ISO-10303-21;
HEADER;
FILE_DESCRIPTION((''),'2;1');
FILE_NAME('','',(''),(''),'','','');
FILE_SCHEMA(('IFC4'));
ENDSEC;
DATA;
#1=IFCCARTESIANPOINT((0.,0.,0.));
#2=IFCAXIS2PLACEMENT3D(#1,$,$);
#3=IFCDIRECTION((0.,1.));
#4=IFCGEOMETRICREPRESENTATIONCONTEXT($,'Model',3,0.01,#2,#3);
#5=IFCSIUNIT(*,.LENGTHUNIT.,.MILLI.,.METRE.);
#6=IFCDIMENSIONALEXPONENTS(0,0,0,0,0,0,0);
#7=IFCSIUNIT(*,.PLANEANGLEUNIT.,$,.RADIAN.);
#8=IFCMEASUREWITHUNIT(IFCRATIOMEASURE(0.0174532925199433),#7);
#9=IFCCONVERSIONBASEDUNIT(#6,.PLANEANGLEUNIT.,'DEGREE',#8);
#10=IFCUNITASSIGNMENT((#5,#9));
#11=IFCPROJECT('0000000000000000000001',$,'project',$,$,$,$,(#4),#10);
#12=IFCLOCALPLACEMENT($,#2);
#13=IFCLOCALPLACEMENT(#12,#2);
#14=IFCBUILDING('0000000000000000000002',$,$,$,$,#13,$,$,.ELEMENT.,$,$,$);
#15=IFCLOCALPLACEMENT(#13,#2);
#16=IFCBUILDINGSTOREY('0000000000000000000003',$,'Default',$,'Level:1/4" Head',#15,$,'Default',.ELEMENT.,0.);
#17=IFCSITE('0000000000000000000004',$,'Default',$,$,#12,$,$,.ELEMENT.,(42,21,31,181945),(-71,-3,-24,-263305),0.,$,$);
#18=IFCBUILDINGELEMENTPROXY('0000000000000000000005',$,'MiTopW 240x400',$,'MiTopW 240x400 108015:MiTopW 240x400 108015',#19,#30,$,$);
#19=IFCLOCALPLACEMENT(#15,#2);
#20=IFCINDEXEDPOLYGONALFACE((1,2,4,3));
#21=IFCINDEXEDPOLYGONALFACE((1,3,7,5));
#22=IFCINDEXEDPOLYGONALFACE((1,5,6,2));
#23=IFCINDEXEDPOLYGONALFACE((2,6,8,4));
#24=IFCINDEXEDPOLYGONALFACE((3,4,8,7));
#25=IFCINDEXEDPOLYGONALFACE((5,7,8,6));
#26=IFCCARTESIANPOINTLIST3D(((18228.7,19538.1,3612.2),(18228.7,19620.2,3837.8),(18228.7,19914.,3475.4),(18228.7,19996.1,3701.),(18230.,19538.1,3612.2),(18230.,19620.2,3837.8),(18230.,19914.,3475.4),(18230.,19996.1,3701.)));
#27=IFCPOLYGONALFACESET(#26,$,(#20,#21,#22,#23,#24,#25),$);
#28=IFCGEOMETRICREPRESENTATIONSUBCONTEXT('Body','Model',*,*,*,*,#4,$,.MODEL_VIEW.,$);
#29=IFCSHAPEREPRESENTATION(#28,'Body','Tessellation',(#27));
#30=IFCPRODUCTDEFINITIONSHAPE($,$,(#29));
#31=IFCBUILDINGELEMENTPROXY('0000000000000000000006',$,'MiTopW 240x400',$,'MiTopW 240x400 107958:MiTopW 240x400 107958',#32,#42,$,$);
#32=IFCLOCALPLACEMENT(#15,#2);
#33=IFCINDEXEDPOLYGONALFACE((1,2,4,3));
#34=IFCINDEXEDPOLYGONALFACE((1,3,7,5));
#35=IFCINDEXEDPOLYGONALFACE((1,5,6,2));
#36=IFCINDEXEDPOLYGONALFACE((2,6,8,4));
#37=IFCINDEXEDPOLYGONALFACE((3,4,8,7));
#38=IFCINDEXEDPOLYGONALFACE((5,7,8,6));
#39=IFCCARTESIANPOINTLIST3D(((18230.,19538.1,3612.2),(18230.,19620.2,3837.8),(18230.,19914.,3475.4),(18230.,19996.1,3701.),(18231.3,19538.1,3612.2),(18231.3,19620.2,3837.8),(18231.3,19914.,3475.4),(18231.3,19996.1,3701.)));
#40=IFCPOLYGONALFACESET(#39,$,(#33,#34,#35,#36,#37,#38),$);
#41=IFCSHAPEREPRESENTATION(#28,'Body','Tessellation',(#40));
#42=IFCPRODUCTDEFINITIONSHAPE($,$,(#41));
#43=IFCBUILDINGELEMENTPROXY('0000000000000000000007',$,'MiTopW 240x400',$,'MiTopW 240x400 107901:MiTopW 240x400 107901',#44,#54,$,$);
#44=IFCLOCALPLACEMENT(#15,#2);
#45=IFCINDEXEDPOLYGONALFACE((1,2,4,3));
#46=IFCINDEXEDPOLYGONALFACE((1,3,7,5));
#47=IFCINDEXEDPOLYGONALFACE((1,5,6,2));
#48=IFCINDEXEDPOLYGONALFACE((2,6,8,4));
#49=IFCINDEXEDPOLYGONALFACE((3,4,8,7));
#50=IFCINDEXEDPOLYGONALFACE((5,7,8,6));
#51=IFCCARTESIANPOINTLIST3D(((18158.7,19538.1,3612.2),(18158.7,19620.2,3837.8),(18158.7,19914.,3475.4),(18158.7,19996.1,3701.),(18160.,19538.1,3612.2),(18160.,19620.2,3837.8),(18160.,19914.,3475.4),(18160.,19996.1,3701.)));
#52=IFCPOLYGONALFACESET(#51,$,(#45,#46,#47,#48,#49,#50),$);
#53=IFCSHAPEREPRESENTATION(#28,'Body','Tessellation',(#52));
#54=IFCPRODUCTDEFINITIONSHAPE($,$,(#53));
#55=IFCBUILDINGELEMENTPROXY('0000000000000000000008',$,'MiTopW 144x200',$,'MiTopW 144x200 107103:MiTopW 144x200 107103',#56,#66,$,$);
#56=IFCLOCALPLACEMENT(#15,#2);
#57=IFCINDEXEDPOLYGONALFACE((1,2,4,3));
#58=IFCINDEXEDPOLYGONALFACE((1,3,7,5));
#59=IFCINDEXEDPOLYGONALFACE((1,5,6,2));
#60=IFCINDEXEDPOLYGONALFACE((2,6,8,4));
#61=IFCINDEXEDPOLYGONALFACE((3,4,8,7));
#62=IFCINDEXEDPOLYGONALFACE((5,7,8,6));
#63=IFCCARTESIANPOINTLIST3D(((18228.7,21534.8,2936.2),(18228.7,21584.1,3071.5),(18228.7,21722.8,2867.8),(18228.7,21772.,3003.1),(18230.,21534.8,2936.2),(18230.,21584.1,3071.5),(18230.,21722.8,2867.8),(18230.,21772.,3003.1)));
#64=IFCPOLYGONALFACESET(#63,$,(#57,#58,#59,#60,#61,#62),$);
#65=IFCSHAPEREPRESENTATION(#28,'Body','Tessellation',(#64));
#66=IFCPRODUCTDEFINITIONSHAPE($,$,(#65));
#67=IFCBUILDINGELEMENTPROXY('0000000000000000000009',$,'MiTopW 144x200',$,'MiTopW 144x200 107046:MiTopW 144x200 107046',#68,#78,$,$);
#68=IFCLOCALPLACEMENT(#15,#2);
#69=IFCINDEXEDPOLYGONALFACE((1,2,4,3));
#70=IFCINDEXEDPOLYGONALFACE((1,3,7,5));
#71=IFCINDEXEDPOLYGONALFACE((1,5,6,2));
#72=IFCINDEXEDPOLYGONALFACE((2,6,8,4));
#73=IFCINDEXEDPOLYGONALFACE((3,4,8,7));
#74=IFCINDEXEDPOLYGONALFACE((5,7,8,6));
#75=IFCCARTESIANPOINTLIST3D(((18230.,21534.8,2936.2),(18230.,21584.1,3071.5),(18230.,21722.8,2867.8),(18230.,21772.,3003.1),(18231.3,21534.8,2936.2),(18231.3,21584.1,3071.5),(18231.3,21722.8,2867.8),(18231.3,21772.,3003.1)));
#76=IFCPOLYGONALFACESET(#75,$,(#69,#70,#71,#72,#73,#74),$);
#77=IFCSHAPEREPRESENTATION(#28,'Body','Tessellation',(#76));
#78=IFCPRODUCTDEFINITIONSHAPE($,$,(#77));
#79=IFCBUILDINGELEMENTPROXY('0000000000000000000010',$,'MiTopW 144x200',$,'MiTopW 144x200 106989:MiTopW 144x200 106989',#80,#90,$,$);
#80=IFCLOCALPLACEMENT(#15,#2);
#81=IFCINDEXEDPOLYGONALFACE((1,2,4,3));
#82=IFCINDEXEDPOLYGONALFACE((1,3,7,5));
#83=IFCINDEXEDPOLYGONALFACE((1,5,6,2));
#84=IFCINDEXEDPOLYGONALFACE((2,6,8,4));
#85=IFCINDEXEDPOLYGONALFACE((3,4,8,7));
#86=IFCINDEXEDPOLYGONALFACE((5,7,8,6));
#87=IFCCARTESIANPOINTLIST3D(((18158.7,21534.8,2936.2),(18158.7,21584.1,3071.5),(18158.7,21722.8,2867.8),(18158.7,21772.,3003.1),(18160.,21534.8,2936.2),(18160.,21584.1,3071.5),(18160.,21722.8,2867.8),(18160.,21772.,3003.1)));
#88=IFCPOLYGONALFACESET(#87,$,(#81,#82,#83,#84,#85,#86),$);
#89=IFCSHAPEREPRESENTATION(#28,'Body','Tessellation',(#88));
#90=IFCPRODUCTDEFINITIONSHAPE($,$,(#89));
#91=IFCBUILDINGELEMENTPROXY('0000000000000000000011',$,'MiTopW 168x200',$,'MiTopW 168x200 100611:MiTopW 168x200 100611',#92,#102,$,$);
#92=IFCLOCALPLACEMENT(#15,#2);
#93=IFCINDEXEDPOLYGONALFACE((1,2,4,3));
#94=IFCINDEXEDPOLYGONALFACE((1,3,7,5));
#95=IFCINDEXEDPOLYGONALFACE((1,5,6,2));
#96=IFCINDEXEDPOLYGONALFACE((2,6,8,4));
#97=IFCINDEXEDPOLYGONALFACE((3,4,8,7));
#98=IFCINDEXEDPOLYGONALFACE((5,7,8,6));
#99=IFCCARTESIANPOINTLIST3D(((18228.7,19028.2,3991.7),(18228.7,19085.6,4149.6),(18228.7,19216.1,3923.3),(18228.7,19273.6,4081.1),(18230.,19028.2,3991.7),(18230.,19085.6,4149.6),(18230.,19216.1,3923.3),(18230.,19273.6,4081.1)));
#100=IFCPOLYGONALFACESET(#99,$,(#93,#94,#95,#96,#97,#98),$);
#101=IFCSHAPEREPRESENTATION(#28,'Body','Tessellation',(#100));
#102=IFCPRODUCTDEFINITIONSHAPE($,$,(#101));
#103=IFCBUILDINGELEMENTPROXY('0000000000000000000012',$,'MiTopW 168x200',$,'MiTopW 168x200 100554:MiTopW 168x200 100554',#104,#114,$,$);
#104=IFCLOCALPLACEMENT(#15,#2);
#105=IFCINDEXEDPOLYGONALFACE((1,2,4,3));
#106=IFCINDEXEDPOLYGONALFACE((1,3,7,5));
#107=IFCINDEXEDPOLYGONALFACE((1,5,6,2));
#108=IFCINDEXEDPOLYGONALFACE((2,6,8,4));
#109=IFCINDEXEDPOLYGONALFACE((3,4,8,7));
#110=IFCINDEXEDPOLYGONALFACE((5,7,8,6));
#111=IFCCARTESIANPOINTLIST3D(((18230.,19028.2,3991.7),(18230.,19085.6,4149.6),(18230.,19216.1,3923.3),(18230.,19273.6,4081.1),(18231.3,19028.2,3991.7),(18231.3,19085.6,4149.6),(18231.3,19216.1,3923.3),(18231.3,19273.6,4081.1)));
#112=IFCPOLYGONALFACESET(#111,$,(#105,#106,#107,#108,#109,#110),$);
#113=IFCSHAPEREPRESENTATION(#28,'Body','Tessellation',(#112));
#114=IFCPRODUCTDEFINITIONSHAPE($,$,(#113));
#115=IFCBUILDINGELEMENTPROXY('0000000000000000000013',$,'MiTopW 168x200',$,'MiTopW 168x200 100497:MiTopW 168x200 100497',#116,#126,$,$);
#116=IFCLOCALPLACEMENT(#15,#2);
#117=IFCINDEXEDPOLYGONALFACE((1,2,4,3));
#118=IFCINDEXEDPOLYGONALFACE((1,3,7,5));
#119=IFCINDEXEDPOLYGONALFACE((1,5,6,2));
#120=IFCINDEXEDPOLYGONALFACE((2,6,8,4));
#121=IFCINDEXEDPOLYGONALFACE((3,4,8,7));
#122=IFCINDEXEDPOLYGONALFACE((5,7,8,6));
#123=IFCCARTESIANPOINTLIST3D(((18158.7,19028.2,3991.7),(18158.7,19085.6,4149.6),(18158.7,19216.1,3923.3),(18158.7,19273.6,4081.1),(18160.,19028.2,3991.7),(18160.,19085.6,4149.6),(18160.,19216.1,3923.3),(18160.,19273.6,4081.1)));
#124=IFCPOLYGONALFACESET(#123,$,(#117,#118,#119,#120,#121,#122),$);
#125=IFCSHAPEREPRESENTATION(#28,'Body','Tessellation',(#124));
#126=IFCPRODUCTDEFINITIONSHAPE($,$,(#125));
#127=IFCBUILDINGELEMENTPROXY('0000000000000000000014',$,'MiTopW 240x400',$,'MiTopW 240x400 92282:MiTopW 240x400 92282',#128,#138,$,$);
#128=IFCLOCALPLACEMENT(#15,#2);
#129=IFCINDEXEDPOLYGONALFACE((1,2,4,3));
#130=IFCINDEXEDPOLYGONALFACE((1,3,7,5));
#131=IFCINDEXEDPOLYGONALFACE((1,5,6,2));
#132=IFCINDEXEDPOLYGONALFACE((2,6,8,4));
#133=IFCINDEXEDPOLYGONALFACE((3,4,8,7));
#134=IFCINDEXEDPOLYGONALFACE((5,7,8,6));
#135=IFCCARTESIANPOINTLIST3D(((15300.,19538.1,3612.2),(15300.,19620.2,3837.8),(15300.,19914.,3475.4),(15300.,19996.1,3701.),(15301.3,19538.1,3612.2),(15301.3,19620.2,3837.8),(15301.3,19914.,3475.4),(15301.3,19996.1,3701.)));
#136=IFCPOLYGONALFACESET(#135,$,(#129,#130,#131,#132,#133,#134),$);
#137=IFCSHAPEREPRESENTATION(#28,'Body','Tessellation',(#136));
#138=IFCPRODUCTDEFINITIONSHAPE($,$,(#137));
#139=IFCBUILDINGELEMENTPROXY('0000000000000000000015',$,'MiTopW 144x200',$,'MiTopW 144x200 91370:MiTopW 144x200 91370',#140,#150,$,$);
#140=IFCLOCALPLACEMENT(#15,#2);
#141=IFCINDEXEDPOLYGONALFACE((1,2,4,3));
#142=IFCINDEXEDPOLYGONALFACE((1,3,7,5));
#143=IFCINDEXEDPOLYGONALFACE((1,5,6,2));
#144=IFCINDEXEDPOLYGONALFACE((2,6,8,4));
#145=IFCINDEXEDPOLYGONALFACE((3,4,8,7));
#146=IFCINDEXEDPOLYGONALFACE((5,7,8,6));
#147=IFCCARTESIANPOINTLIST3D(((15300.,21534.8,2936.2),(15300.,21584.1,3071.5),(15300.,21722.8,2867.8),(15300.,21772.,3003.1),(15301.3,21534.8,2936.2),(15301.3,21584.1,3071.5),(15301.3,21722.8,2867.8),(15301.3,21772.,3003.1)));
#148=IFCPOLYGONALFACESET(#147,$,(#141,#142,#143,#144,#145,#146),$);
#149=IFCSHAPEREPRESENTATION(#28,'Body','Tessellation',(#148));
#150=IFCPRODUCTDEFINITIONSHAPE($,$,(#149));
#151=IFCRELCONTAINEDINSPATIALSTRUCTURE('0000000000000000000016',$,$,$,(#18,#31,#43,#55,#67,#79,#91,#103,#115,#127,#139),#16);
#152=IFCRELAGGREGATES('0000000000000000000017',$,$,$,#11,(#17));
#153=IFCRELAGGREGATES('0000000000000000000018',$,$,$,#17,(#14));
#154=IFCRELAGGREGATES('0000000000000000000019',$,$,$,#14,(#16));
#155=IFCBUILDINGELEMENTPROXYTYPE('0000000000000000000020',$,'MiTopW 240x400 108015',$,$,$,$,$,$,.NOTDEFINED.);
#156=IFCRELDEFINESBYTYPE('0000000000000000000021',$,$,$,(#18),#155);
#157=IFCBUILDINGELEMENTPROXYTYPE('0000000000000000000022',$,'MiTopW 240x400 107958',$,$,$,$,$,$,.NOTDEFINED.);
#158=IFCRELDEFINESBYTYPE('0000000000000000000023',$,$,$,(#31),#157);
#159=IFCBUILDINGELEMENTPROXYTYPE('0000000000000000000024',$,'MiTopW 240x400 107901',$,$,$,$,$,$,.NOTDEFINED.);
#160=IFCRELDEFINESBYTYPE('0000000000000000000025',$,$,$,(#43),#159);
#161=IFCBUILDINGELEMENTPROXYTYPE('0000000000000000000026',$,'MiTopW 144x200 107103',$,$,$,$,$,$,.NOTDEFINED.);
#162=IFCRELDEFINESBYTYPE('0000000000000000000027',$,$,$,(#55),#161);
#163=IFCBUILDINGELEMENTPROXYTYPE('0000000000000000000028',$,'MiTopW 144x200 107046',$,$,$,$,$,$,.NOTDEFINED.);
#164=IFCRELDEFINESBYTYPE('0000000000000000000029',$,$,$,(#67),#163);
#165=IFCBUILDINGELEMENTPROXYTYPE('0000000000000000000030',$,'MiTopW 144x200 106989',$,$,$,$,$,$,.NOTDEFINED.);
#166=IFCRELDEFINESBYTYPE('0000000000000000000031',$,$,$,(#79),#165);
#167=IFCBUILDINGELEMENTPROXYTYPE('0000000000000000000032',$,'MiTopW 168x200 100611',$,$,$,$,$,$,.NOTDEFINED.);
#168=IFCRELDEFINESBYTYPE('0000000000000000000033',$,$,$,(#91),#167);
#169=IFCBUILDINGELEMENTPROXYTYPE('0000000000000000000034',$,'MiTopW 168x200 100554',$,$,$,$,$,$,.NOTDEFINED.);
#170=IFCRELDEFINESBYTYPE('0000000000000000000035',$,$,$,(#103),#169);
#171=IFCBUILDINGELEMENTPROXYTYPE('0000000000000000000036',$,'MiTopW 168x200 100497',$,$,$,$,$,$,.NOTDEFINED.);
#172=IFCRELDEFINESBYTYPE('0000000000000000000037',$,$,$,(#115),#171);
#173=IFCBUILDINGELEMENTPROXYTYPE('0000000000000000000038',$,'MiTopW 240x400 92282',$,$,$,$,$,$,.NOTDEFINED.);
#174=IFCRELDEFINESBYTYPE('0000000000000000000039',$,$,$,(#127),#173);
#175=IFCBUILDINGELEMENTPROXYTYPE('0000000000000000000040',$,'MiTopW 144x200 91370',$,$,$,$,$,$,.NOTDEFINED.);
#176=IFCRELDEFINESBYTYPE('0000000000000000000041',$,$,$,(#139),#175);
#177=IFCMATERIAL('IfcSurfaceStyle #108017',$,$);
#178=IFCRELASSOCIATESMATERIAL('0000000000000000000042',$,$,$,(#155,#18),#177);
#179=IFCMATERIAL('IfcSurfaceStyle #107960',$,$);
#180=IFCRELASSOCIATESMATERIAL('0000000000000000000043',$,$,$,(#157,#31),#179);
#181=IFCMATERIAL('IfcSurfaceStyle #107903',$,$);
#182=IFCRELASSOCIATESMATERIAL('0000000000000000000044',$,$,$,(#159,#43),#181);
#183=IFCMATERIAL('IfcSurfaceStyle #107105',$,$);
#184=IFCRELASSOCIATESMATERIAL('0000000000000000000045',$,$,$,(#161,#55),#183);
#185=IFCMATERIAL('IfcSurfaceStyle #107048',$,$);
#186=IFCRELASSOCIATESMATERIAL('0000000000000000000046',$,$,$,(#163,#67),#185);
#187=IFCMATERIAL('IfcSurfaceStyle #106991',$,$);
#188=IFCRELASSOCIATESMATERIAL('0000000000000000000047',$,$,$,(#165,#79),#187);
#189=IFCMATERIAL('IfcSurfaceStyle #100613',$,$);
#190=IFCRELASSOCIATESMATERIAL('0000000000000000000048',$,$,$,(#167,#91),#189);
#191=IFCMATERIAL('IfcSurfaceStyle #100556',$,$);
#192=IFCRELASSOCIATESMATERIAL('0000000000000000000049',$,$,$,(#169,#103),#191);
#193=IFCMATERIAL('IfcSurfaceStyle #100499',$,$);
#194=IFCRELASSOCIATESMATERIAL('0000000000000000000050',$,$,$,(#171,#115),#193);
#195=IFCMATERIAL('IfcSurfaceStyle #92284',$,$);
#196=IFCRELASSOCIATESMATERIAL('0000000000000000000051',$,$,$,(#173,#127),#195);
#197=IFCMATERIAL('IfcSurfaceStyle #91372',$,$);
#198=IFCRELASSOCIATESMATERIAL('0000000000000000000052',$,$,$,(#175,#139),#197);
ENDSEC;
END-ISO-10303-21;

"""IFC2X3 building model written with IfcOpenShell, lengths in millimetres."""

from ifc_helpers import new_model, entity, si_unit, converted_unit, direction, frame, origin, place, context, subcontext, project, spatial, polyline, outline, extrude, source, transform, mapped, material, type_object, type_shapes, element, save


model = new_model("IFC2X3")

# Units and contexts
model_context = context("Model", 3, precision=0.01, world=origin(), true_north=direction((0.0, 1.0)))
body_context = subcontext(model_context, "Body", "Model", "MODEL_VIEW")
ifc_project = project(units=[si_unit("LENGTHUNIT", "METRE", prefix="MILLI"), converted_unit("PLANEANGLEUNIT", "DEGREE", entity("IfcRatioMeasure", 0.0174532925199433), si_unit("PLANEANGLEUNIT", "RADIAN"), dimensions=[0, 0, 0, 0, 0, 0, 0])], contexts=[model_context])

# Site, building, storey
site_placement = place(None, origin())
site = spatial("IfcSite", under=ifc_project, at=site_placement, Name="Default", CompositionType="ELEMENT", RefLatitude=(42, 21, 31, 181945), RefLongitude=(-71, -3, -24, -263305), RefElevation=0.0)
building_placement = place(site_placement, origin())
building = spatial("IfcBuilding", under=site, at=building_placement, CompositionType="ELEMENT")
storey_placement = place(building_placement, origin())
storey = spatial("IfcBuildingStorey", under=building, at=storey_placement, Name="Default", ObjectType="Level:1/4\" Head", LongName="Default", CompositionType="ELEMENT", Elevation=0.0)

# Building element proxies
ifc_material_1 = material(Name="IfcSurfaceStyle #108017")
building_element_proxy_type_1 = type_object("IfcBuildingElementProxyType", Name="MiTopW 240x400 108015", PredefinedType="NOTDEFINED", material=ifc_material_1)
shared_shape_1 = source(origin(), body_context, "Body", "SweptSolid", [
    extrude(outline(polyline([(-200.0, -120.0), (200.0, -120.0), (200.0, 120.0), (-200.0, 120.0), (-200.0, -120.0)])), frame((200.0, 120.0, 0.0), z_axis=(0.0, 0.0, 1.0), x_axis=(-1.0, 0.0, 0.0)), (0.0, 0.0, 1.0), 1.3),
])
type_shapes(building_element_proxy_type_1, [shared_shape_1])
proxy_1_placement = place(building_placement, frame((18230.0, 19620.2, 3837.8), z_axis=(-1.0, 0.0, 0.0), x_axis=(0.0, 0.939693, -0.34202)))
element("IfcBuildingElementProxy", 1, at=proxy_1_placement, inside=storey, type_object=building_element_proxy_type_1, material=ifc_material_1, Name="MiTopW 240x400", ObjectType="MiTopW 240x400 108015:MiTopW 240x400 108015", context=body_context, shape_type="MappedRepresentation", body=[
    mapped(shared_shape_1, transform((0.0, 0.0, 0.0), scale=1.0)),
])
ifc_material_2 = material(Name="IfcSurfaceStyle #107960")
building_element_proxy_type_2 = type_object("IfcBuildingElementProxyType", Name="MiTopW 240x400 107958", PredefinedType="NOTDEFINED", material=ifc_material_2)
shared_shape_2 = source(origin(), body_context, "Body", "SweptSolid", [
    extrude(outline(polyline([(-200.0, -120.0), (200.0, -120.0), (200.0, 120.0), (-200.0, 120.0), (-200.0, -120.0)])), frame((200.0, 120.0, 0.0), z_axis=(0.0, 0.0, 1.0), x_axis=(-1.0, 0.0, 0.0)), (0.0, 0.0, 1.0), 1.3),
])
type_shapes(building_element_proxy_type_2, [shared_shape_2])
proxy_2_placement = place(building_placement, frame((18231.3, 19620.2, 3837.8), z_axis=(-1.0, 0.0, 0.0), x_axis=(0.0, 0.939693, -0.34202)))
element("IfcBuildingElementProxy", 2, at=proxy_2_placement, inside=storey, type_object=building_element_proxy_type_2, material=ifc_material_2, Name="MiTopW 240x400", ObjectType="MiTopW 240x400 107958:MiTopW 240x400 107958", context=body_context, shape_type="MappedRepresentation", body=[
    mapped(shared_shape_2, transform((0.0, 0.0, 0.0), scale=1.0)),
])
ifc_material_3 = material(Name="IfcSurfaceStyle #107903")
building_element_proxy_type_3 = type_object("IfcBuildingElementProxyType", Name="MiTopW 240x400 107901", PredefinedType="NOTDEFINED", material=ifc_material_3)
shared_shape_3 = source(origin(), body_context, "Body", "SweptSolid", [
    extrude(outline(polyline([(-200.0, -120.0), (200.0, -120.0), (200.0, 120.0), (-200.0, 120.0), (-200.0, -120.0)])), frame((200.0, 120.0, 0.0), z_axis=(0.0, 0.0, 1.0), x_axis=(-1.0, 0.0, 0.0)), (0.0, 0.0, 1.0), 1.3),
])
type_shapes(building_element_proxy_type_3, [shared_shape_3])
proxy_3_placement = place(building_placement, frame((18160.0, 19620.2, 3837.8), z_axis=(-1.0, 0.0, 0.0), x_axis=(0.0, 0.939693, -0.34202)))
element("IfcBuildingElementProxy", 3, at=proxy_3_placement, inside=storey, type_object=building_element_proxy_type_3, material=ifc_material_3, Name="MiTopW 240x400", ObjectType="MiTopW 240x400 107901:MiTopW 240x400 107901", context=body_context, shape_type="MappedRepresentation", body=[
    mapped(shared_shape_3, transform((0.0, 0.0, 0.0), scale=1.0)),
])
ifc_material_4 = material(Name="IfcSurfaceStyle #107105")
building_element_proxy_type_4 = type_object("IfcBuildingElementProxyType", Name="MiTopW 144x200 107103", PredefinedType="NOTDEFINED", material=ifc_material_4)
shared_shape_4 = source(origin(), body_context, "Body", "SweptSolid", [
    extrude(outline(polyline([(-100.0, -72.0), (100.0, -72.0), (100.0, 72.0), (-100.0, 72.0), (-100.0, -72.0)])), frame((100.0, 72.0, 0.0), z_axis=(0.0, 0.0, 1.0), x_axis=(-1.0, 0.0, 0.0)), (0.0, 0.0, 1.0), 1.3),
])
type_shapes(building_element_proxy_type_4, [shared_shape_4])
proxy_4_placement = place(building_placement, frame((18230.0, 21584.1, 3071.5), z_axis=(-1.0, 0.0, 0.0), x_axis=(0.0, 0.939693, -0.34202)))
element("IfcBuildingElementProxy", 4, at=proxy_4_placement, inside=storey, type_object=building_element_proxy_type_4, material=ifc_material_4, Name="MiTopW 144x200", ObjectType="MiTopW 144x200 107103:MiTopW 144x200 107103", context=body_context, shape_type="MappedRepresentation", body=[
    mapped(shared_shape_4, transform((0.0, 0.0, 0.0), scale=1.0)),
])
ifc_material_5 = material(Name="IfcSurfaceStyle #107048")
building_element_proxy_type_5 = type_object("IfcBuildingElementProxyType", Name="MiTopW 144x200 107046", PredefinedType="NOTDEFINED", material=ifc_material_5)
shared_shape_5 = source(origin(), body_context, "Body", "SweptSolid", [
    extrude(outline(polyline([(-100.0, -72.0), (100.0, -72.0), (100.0, 72.0), (-100.0, 72.0), (-100.0, -72.0)])), frame((100.0, 72.0, 0.0), z_axis=(0.0, 0.0, 1.0), x_axis=(-1.0, 0.0, 0.0)), (0.0, 0.0, 1.0), 1.3),
])
type_shapes(building_element_proxy_type_5, [shared_shape_5])
proxy_5_placement = place(building_placement, frame((18231.3, 21584.1, 3071.5), z_axis=(-1.0, 0.0, 0.0), x_axis=(0.0, 0.939693, -0.34202)))
element("IfcBuildingElementProxy", 5, at=proxy_5_placement, inside=storey, type_object=building_element_proxy_type_5, material=ifc_material_5, Name="MiTopW 144x200", ObjectType="MiTopW 144x200 107046:MiTopW 144x200 107046", context=body_context, shape_type="MappedRepresentation", body=[
    mapped(shared_shape_5, transform((0.0, 0.0, 0.0), scale=1.0)),
])
ifc_material_6 = material(Name="IfcSurfaceStyle #106991")
building_element_proxy_type_6 = type_object("IfcBuildingElementProxyType", Name="MiTopW 144x200 106989", PredefinedType="NOTDEFINED", material=ifc_material_6)
shared_shape_6 = source(origin(), body_context, "Body", "SweptSolid", [
    extrude(outline(polyline([(-100.0, -72.0), (100.0, -72.0), (100.0, 72.0), (-100.0, 72.0), (-100.0, -72.0)])), frame((100.0, 72.0, 0.0), z_axis=(0.0, 0.0, 1.0), x_axis=(-1.0, 0.0, 0.0)), (0.0, 0.0, 1.0), 1.3),
])
type_shapes(building_element_proxy_type_6, [shared_shape_6])
proxy_6_placement = place(building_placement, frame((18160.0, 21584.1, 3071.5), z_axis=(-1.0, 0.0, 0.0), x_axis=(0.0, 0.939693, -0.34202)))
element("IfcBuildingElementProxy", 6, at=proxy_6_placement, inside=storey, type_object=building_element_proxy_type_6, material=ifc_material_6, Name="MiTopW 144x200", ObjectType="MiTopW 144x200 106989:MiTopW 144x200 106989", context=body_context, shape_type="MappedRepresentation", body=[
    mapped(shared_shape_6, transform((0.0, 0.0, 0.0), scale=1.0)),
])
ifc_material_7 = material(Name="IfcSurfaceStyle #100613")
building_element_proxy_type_7 = type_object("IfcBuildingElementProxyType", Name="MiTopW 168x200 100611", PredefinedType="NOTDEFINED", material=ifc_material_7)
shared_shape_7 = source(origin(), body_context, "Body", "SweptSolid", [
    extrude(outline(polyline([(-100.0, -84.0), (100.0, -84.0), (100.0, 84.0), (-100.0, 84.0), (-100.0, -84.0)])), frame((100.0, 84.0, 0.0), z_axis=(0.0, 0.0, 1.0), x_axis=(-1.0, 0.0, 0.0)), (0.0, 0.0, 1.0), 1.3),
])
type_shapes(building_element_proxy_type_7, [shared_shape_7])
proxy_7_placement = place(building_placement, frame((18230.0, 19216.1, 3923.3), z_axis=(-1.0, 0.0, 0.0), x_axis=(0.0, -0.939693, 0.34202)))
element("IfcBuildingElementProxy", 7, at=proxy_7_placement, inside=storey, type_object=building_element_proxy_type_7, material=ifc_material_7, Name="MiTopW 168x200", ObjectType="MiTopW 168x200 100611:MiTopW 168x200 100611", context=body_context, shape_type="MappedRepresentation", body=[
    mapped(shared_shape_7, transform((0.0, 0.0, 0.0), scale=1.0)),
])
ifc_material_8 = material(Name="IfcSurfaceStyle #100556")
building_element_proxy_type_8 = type_object("IfcBuildingElementProxyType", Name="MiTopW 168x200 100554", PredefinedType="NOTDEFINED", material=ifc_material_8)
shared_shape_8 = source(origin(), body_context, "Body", "SweptSolid", [
    extrude(outline(polyline([(-100.0, -84.0), (100.0, -84.0), (100.0, 84.0), (-100.0, 84.0), (-100.0, -84.0)])), frame((100.0, 84.0, 0.0), z_axis=(0.0, 0.0, 1.0), x_axis=(-1.0, 0.0, 0.0)), (0.0, 0.0, 1.0), 1.3),
])
type_shapes(building_element_proxy_type_8, [shared_shape_8])
proxy_8_placement = place(building_placement, frame((18231.3, 19216.1, 3923.3), z_axis=(-1.0, 0.0, 0.0), x_axis=(0.0, -0.939693, 0.34202)))
element("IfcBuildingElementProxy", 8, at=proxy_8_placement, inside=storey, type_object=building_element_proxy_type_8, material=ifc_material_8, Name="MiTopW 168x200", ObjectType="MiTopW 168x200 100554:MiTopW 168x200 100554", context=body_context, shape_type="MappedRepresentation", body=[
    mapped(shared_shape_8, transform((0.0, 0.0, 0.0), scale=1.0)),
])
ifc_material_9 = material(Name="IfcSurfaceStyle #100499")
building_element_proxy_type_9 = type_object("IfcBuildingElementProxyType", Name="MiTopW 168x200 100497", PredefinedType="NOTDEFINED", material=ifc_material_9)
shared_shape_9 = source(origin(), body_context, "Body", "SweptSolid", [
    extrude(outline(polyline([(-100.0, -84.0), (100.0, -84.0), (100.0, 84.0), (-100.0, 84.0), (-100.0, -84.0)])), frame((100.0, 84.0, 0.0), z_axis=(0.0, 0.0, 1.0), x_axis=(-1.0, 0.0, 0.0)), (0.0, 0.0, 1.0), 1.3),
])
type_shapes(building_element_proxy_type_9, [shared_shape_9])
proxy_9_placement = place(building_placement, frame((18160.0, 19216.1, 3923.3), z_axis=(-1.0, 0.0, 0.0), x_axis=(0.0, -0.939693, 0.34202)))
element("IfcBuildingElementProxy", 9, at=proxy_9_placement, inside=storey, type_object=building_element_proxy_type_9, material=ifc_material_9, Name="MiTopW 168x200", ObjectType="MiTopW 168x200 100497:MiTopW 168x200 100497", context=body_context, shape_type="MappedRepresentation", body=[
    mapped(shared_shape_9, transform((0.0, 0.0, 0.0), scale=1.0)),
])
ifc_material_10 = material(Name="IfcSurfaceStyle #92284")
building_element_proxy_type_10 = type_object("IfcBuildingElementProxyType", Name="MiTopW 240x400 92282", PredefinedType="NOTDEFINED", material=ifc_material_10)
shared_shape_10 = source(origin(), body_context, "Body", "SweptSolid", [
    extrude(outline(polyline([(-200.0, -120.0), (200.0, -120.0), (200.0, 120.0), (-200.0, 120.0), (-200.0, -120.0)])), frame((200.0, 120.0, 0.0), z_axis=(0.0, 0.0, 1.0), x_axis=(-1.0, 0.0, 0.0)), (0.0, 0.0, 1.0), 1.3),
])
type_shapes(building_element_proxy_type_10, [shared_shape_10])
proxy_10_placement = place(building_placement, frame((15301.3, 19620.2, 3837.8), z_axis=(-1.0, 0.0, 0.0), x_axis=(0.0, 0.939693, -0.34202)))
element("IfcBuildingElementProxy", 10, at=proxy_10_placement, inside=storey, type_object=building_element_proxy_type_10, material=ifc_material_10, Name="MiTopW 240x400", ObjectType="MiTopW 240x400 92282:MiTopW 240x400 92282", context=body_context, shape_type="MappedRepresentation", body=[
    mapped(shared_shape_10, transform((0.0, 0.0, 0.0), scale=1.0)),
])
ifc_material_11 = material(Name="IfcSurfaceStyle #91372")
building_element_proxy_type_11 = type_object("IfcBuildingElementProxyType", Name="MiTopW 144x200 91370", PredefinedType="NOTDEFINED", material=ifc_material_11)
shared_shape_11 = source(origin(), body_context, "Body", "SweptSolid", [
    extrude(outline(polyline([(-100.0, -72.0), (100.0, -72.0), (100.0, 72.0), (-100.0, 72.0), (-100.0, -72.0)])), frame((100.0, 72.0, 0.0), z_axis=(0.0, 0.0, 1.0), x_axis=(-1.0, 0.0, 0.0)), (0.0, 0.0, 1.0), 1.3),
])
type_shapes(building_element_proxy_type_11, [shared_shape_11])
proxy_11_placement = place(building_placement, frame((15301.3, 21584.1, 3071.5), z_axis=(-1.0, 0.0, 0.0), x_axis=(0.0, 0.939693, -0.34202)))
element("IfcBuildingElementProxy", 11, at=proxy_11_placement, inside=storey, type_object=building_element_proxy_type_11, material=ifc_material_11, Name="MiTopW 144x200", ObjectType="MiTopW 144x200 91370:MiTopW 144x200 91370", context=body_context, shape_type="MappedRepresentation", body=[
    mapped(shared_shape_11, transform((0.0, 0.0, 0.0), scale=1.0)),
])

save(model, "model.ifc")
